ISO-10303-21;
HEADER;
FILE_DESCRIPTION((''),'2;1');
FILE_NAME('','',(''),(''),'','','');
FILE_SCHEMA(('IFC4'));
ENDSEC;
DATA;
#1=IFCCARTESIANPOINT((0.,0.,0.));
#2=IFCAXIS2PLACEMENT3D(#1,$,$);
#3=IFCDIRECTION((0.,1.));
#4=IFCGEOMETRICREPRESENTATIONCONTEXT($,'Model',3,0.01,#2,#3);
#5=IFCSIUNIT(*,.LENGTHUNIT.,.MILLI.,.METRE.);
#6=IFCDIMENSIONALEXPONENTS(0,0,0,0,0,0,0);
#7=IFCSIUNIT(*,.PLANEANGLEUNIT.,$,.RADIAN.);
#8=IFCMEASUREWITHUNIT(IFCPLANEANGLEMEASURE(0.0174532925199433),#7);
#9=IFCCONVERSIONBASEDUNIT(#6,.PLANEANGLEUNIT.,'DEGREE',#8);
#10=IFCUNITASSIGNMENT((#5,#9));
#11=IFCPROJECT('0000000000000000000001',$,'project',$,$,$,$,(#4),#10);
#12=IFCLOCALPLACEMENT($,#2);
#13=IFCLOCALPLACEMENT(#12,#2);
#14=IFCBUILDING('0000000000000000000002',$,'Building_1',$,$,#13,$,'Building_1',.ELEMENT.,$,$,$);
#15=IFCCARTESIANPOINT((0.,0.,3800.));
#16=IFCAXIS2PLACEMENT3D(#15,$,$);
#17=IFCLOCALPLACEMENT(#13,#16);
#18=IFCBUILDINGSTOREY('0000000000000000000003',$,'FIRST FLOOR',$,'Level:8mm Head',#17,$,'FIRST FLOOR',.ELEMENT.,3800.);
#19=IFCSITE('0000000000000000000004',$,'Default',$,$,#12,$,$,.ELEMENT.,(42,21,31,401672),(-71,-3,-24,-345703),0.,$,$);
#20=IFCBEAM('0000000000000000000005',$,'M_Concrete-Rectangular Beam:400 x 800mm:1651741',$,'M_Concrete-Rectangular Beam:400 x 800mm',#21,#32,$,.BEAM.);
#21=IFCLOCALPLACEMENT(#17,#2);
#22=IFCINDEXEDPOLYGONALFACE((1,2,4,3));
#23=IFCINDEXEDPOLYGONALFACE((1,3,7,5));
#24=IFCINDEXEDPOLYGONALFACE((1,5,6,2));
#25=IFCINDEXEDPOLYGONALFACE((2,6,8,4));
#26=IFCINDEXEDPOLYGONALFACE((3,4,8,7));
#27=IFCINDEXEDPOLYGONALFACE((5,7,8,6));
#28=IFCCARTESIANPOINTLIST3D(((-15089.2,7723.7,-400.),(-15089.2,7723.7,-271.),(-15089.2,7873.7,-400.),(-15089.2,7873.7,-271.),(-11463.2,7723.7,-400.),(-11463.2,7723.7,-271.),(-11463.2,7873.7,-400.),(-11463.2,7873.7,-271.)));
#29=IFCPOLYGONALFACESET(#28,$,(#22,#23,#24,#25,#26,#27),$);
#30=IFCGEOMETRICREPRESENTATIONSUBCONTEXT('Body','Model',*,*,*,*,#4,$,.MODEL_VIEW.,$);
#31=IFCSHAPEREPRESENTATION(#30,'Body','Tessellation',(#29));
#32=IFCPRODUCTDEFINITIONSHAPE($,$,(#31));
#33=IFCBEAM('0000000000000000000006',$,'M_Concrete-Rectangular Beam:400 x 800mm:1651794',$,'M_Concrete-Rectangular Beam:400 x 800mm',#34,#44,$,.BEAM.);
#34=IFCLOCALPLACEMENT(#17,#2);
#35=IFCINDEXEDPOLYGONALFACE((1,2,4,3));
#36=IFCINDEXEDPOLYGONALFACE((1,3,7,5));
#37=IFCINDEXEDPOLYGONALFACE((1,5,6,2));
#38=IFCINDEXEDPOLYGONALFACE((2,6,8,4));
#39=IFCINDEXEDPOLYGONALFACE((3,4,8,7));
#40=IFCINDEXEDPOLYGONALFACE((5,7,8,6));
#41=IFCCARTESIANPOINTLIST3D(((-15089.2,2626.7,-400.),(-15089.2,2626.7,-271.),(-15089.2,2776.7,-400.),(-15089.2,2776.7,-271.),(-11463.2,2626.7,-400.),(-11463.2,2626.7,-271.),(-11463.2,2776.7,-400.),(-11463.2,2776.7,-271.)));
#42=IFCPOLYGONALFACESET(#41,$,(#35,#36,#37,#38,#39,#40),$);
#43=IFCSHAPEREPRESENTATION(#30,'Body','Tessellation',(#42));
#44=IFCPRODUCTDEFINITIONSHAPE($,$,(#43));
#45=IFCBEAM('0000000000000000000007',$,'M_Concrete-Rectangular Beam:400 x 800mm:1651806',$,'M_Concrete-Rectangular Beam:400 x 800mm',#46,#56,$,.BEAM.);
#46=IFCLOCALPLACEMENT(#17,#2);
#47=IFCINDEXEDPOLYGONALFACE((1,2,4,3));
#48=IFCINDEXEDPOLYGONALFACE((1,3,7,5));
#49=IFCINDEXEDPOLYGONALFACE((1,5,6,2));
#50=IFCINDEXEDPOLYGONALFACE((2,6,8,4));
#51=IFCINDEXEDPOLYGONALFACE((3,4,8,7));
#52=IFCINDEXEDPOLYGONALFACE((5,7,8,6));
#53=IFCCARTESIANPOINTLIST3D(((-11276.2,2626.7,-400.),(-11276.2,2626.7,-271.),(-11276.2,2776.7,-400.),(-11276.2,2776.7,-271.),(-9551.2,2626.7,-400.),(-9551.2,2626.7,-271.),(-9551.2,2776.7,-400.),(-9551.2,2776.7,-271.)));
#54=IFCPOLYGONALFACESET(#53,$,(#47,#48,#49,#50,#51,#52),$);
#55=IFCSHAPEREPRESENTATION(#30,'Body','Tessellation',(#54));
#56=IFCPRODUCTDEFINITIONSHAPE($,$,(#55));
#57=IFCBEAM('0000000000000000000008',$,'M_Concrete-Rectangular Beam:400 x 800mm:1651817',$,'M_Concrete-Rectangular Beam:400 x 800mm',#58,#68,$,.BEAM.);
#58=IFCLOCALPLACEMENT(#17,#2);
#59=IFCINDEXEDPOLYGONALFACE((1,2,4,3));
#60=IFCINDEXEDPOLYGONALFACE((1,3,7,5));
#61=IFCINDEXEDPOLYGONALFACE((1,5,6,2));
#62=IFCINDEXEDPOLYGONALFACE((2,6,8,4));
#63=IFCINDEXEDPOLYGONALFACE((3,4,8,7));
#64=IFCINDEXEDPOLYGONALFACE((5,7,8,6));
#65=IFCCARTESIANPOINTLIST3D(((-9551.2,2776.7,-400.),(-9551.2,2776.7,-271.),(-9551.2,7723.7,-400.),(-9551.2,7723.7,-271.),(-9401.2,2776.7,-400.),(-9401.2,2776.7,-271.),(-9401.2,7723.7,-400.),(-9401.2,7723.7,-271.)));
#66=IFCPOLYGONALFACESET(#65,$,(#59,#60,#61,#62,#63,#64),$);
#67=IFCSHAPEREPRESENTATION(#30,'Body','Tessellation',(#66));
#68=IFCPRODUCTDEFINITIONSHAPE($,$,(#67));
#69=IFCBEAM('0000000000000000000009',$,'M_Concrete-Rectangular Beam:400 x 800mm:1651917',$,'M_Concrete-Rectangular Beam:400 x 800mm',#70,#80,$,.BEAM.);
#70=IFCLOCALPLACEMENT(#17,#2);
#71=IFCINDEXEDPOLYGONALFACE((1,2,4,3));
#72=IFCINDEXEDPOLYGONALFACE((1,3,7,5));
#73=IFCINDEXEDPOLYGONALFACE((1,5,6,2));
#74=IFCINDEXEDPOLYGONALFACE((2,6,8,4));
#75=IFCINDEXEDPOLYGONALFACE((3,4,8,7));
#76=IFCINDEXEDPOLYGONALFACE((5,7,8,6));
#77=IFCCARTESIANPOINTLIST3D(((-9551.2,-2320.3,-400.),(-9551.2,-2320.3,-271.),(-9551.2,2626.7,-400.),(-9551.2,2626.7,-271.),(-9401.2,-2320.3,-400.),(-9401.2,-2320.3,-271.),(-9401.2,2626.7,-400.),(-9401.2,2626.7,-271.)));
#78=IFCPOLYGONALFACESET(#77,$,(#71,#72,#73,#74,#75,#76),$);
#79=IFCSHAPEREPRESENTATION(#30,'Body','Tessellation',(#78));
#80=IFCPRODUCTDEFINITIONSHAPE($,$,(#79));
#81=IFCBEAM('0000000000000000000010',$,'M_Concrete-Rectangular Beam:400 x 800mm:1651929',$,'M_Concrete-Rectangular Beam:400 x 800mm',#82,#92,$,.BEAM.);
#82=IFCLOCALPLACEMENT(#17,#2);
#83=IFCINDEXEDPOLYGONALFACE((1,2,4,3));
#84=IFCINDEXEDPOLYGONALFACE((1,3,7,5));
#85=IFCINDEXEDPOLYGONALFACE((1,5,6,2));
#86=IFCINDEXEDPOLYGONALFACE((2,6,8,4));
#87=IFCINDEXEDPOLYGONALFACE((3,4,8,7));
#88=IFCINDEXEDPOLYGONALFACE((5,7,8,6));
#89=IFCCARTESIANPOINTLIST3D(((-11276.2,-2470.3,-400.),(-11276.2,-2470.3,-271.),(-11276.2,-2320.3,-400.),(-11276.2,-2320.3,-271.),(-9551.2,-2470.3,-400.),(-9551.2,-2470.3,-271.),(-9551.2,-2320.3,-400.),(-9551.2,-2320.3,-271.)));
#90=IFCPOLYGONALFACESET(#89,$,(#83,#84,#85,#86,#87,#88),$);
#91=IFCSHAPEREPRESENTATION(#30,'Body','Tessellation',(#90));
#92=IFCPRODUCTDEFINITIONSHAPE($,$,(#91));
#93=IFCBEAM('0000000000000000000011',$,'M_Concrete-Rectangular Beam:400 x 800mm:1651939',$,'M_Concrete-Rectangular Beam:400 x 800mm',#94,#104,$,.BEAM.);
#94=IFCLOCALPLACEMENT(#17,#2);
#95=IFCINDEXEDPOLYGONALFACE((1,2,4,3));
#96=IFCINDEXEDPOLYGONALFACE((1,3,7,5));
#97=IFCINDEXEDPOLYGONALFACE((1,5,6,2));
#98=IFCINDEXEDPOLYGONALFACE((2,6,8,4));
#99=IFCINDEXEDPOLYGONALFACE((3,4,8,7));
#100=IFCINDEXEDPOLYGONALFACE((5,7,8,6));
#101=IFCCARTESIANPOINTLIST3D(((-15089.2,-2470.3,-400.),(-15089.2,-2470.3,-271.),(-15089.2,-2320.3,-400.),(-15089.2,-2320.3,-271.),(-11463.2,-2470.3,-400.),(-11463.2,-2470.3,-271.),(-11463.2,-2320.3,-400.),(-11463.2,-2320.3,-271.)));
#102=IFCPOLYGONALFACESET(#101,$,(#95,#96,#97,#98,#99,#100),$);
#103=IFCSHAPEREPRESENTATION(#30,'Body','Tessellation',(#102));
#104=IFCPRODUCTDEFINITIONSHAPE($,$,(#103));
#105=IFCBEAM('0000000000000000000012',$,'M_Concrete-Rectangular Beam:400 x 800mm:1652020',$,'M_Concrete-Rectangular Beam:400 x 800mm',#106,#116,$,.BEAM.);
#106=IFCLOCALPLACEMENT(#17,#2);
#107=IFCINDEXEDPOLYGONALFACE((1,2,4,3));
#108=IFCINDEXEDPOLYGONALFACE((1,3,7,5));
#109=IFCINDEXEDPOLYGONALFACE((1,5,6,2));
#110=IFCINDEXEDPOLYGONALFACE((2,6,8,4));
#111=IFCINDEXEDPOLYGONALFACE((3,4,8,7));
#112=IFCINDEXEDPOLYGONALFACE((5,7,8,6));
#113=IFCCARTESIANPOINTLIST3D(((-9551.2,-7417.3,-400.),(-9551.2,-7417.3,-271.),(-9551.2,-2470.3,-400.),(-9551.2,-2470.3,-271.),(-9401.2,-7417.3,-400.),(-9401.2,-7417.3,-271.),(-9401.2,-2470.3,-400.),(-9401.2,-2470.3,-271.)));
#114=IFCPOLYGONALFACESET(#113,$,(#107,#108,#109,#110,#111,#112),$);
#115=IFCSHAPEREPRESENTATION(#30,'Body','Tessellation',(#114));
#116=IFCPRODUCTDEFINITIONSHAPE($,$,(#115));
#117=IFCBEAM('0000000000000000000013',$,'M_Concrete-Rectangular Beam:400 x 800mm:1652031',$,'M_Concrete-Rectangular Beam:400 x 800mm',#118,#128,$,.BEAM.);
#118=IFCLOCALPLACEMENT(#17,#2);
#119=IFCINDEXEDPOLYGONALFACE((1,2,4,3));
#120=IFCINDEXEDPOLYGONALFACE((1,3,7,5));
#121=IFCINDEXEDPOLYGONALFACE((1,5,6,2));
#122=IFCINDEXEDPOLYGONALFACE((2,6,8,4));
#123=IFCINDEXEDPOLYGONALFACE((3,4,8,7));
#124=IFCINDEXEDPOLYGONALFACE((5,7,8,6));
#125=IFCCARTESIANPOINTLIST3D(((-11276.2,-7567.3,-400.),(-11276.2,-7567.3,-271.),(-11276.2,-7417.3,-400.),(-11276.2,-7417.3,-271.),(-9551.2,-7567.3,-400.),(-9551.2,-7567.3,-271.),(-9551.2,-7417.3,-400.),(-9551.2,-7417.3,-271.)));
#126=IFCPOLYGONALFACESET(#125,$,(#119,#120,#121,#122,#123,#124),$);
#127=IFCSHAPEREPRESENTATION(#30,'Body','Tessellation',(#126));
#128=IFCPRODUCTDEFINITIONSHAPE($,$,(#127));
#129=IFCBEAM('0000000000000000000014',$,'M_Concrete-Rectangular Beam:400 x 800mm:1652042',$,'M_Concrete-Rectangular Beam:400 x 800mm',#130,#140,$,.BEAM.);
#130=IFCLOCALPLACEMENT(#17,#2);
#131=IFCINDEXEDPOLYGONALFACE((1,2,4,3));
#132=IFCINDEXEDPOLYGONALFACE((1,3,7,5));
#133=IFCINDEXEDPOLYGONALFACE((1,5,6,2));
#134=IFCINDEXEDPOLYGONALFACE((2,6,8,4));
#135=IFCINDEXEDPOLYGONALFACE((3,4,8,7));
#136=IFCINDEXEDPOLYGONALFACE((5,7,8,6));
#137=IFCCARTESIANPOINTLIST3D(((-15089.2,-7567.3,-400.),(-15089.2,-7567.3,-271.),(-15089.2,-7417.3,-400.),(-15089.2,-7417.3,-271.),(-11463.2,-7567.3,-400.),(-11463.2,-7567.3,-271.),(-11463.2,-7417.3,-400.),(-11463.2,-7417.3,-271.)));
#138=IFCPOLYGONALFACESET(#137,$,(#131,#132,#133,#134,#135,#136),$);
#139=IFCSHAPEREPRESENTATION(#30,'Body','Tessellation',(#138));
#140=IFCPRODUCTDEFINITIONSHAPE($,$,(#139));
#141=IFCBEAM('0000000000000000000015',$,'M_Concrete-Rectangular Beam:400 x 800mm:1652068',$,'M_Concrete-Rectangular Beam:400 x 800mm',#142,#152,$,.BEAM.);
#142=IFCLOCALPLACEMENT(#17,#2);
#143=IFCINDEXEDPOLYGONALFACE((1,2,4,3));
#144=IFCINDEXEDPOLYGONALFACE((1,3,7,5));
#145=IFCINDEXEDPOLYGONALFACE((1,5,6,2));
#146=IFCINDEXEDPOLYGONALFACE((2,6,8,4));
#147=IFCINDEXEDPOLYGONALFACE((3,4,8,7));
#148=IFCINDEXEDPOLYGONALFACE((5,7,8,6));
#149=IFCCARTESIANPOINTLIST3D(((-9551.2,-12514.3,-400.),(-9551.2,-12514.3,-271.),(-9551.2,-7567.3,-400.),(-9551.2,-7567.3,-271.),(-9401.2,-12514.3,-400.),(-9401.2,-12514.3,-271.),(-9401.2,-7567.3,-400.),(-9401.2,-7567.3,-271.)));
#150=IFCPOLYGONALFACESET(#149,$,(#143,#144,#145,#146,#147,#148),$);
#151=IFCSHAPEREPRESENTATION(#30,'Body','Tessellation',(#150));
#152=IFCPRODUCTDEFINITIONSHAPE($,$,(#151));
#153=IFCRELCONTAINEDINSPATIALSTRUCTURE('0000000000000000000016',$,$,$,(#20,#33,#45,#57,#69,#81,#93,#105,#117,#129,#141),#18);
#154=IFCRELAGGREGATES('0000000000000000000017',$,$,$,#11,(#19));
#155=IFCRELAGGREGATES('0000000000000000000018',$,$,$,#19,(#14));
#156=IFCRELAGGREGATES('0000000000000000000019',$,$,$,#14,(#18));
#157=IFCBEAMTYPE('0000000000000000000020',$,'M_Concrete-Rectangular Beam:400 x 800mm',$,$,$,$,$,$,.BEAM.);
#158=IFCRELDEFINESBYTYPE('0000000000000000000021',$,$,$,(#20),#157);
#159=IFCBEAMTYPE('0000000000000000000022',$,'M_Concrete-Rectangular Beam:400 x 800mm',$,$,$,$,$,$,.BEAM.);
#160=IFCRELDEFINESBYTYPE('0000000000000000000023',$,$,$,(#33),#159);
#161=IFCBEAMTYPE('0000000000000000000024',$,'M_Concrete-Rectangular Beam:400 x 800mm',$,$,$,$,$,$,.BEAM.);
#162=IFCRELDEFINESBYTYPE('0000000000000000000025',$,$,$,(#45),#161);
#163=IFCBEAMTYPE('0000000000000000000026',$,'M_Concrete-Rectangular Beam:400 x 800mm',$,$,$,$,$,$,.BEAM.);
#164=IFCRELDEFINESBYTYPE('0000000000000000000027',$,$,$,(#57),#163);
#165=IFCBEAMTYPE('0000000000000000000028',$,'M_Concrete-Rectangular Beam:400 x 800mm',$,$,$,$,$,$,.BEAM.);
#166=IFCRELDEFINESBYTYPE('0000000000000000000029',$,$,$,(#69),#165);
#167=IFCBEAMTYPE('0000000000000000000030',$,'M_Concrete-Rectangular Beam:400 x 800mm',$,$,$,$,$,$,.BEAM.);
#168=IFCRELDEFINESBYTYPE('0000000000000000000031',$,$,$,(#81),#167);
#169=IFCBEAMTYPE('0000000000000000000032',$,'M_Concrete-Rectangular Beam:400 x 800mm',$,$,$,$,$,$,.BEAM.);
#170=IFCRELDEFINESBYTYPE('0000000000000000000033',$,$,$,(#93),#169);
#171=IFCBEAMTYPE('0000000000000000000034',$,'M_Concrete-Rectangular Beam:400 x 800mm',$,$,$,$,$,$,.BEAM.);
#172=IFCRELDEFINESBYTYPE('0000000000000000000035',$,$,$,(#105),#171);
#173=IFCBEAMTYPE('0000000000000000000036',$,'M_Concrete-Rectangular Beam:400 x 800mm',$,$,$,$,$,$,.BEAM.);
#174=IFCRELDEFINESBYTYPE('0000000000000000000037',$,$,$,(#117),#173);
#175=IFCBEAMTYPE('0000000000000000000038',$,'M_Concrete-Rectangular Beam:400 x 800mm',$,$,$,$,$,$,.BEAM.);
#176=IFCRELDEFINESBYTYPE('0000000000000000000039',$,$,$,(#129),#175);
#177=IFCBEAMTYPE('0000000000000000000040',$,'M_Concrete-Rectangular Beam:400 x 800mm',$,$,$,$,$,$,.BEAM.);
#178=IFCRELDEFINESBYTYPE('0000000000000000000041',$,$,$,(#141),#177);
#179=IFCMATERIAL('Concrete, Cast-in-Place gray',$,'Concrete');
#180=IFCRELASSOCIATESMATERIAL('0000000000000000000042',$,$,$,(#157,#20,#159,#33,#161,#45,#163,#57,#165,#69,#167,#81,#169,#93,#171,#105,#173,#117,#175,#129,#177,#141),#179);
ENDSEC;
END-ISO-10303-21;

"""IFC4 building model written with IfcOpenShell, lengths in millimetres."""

from ifc_helpers import new_model, entity, si_unit, converted_unit, direction, frame, origin, place, context, subcontext, project, spatial, indexed_curve, outline, extrude, source, transform, mapped, material, type_object, type_shapes, element, save


model = new_model("IFC4")

# Units and contexts
model_context = context("Model", 3, precision=0.01, world=origin(), true_north=direction((0.0, 1.0)))
body_context = subcontext(model_context, "Body", "Model", "MODEL_VIEW")
ifc_project = project(units=[si_unit("LENGTHUNIT", "METRE", prefix="MILLI"), converted_unit("PLANEANGLEUNIT", "DEGREE", entity("IfcPlaneAngleMeasure", 0.0174532925199433), si_unit("PLANEANGLEUNIT", "RADIAN"), dimensions=[0, 0, 0, 0, 0, 0, 0])], contexts=[model_context])

# Site, building, storey
site_placement = place(None, origin())
site = spatial("IfcSite", under=ifc_project, at=site_placement, Name="Default", CompositionType="ELEMENT", RefLatitude=(42, 21, 31, 401672), RefLongitude=(-71, -3, -24, -345703), RefElevation=0.0)
building_placement = place(site_placement, origin())
building = spatial("IfcBuilding", under=site, at=building_placement, Name="Building_1", LongName="Building_1", CompositionType="ELEMENT")
storey_placement = place(building_placement, frame((0.0, 0.0, 3800.0)))
storey = spatial("IfcBuildingStorey", under=building, at=storey_placement, Name="FIRST FLOOR", ObjectType="Level:8mm Head", LongName="FIRST FLOOR", CompositionType="ELEMENT", Elevation=3800.0)

# Beams
ifc_material = material(Name="Concrete, Cast-in-Place gray", Category="Concrete")
beam_type_1 = type_object("IfcBeamType", Name="M_Concrete-Rectangular Beam:400 x 800mm", PredefinedType="BEAM", material=ifc_material)
shared_shape_1 = source(origin(), body_context, "Body", "SweptSolid", [
    extrude(outline(indexed_curve([(-64.5, -75.0), (64.5, -75.0), (64.5, 75.0), (-64.5, 75.0), (-64.5, -75.0)], self_intersect=False)), frame((-11463.2, 7798.7, 3464.5), z_axis=(-1.0, 0.0, 0.0), x_axis=(0.0, 0.0, -1.0)), (0.0, 0.0, 1.0), 3626.0),
])
type_shapes(beam_type_1, [shared_shape_1])
beam_1_placement = place(storey_placement, frame((0.0, 0.0, -3800.0)))
element("IfcBeam", 1, at=beam_1_placement, inside=storey, type_object=beam_type_1, material=ifc_material, Name="M_Concrete-Rectangular Beam:400 x 800mm:1651741", ObjectType="M_Concrete-Rectangular Beam:400 x 800mm", PredefinedType="BEAM", context=body_context, shape_type="MappedRepresentation", body=[
    mapped(shared_shape_1, transform((0.0, 0.0, 0.0), scale=1.0)),
])
beam_type_2 = type_object("IfcBeamType", Name="M_Concrete-Rectangular Beam:400 x 800mm", PredefinedType="BEAM", material=ifc_material)
shared_shape_2 = source(origin(), body_context, "Body", "SweptSolid", [
    extrude(outline(indexed_curve([(-64.5, -75.0), (64.5, -75.0), (64.5, 75.0), (-64.5, 75.0), (-64.5, -75.0)], self_intersect=False)), frame((-15089.2, 2701.7, 3464.5), z_axis=(1.0, 0.0, 0.0), x_axis=(0.0, 0.0, -1.0)), (0.0, 0.0, 1.0), 3626.0),
])
type_shapes(beam_type_2, [shared_shape_2])
beam_2_placement = place(storey_placement, frame((0.0, 0.0, -3800.0)))
element("IfcBeam", 2, at=beam_2_placement, inside=storey, type_object=beam_type_2, material=ifc_material, Name="M_Concrete-Rectangular Beam:400 x 800mm:1651794", ObjectType="M_Concrete-Rectangular Beam:400 x 800mm", PredefinedType="BEAM", context=body_context, shape_type="MappedRepresentation", body=[
    mapped(shared_shape_2, transform((0.0, 0.0, 0.0), scale=1.0)),
])
beam_type_3 = type_object("IfcBeamType", Name="M_Concrete-Rectangular Beam:400 x 800mm", PredefinedType="BEAM", material=ifc_material)
shared_shape_3 = source(origin(), body_context, "Body", "SweptSolid", [
    extrude(outline(indexed_curve([(-64.5, -75.0), (64.5, -75.0), (64.5, 75.0), (-64.5, 75.0), (-64.5, -75.0)], self_intersect=False)), frame((-11276.2, 2701.7, 3464.5), z_axis=(1.0, 0.0, 0.0), x_axis=(0.0, 0.0, -1.0)), (0.0, 0.0, 1.0), 1725.0),
])
type_shapes(beam_type_3, [shared_shape_3])
beam_3_placement = place(storey_placement, frame((0.0, 0.0, -3800.0)))
element("IfcBeam", 3, at=beam_3_placement, inside=storey, type_object=beam_type_3, material=ifc_material, Name="M_Concrete-Rectangular Beam:400 x 800mm:1651806", ObjectType="M_Concrete-Rectangular Beam:400 x 800mm", PredefinedType="BEAM", context=body_context, shape_type="MappedRepresentation", body=[
    mapped(shared_shape_3, transform((0.0, 0.0, 0.0), scale=1.0)),
])
beam_type_4 = type_object("IfcBeamType", Name="M_Concrete-Rectangular Beam:400 x 800mm", PredefinedType="BEAM", material=ifc_material)
shared_shape_4 = source(origin(), body_context, "Body", "SweptSolid", [
    extrude(outline(indexed_curve([(-75.0, -64.5), (75.0, -64.5), (75.0, 64.5), (-75.0, 64.5), (-75.0, -64.5)], self_intersect=False)), frame((-9476.2, 2776.7, 3464.5), z_axis=(0.0, 1.0, 0.0), x_axis=(-1.0, 0.0, 0.0)), (0.0, 0.0, 1.0), 4947.0),
])
type_shapes(beam_type_4, [shared_shape_4])
beam_4_placement = place(storey_placement, frame((0.0, 0.0, -3800.0)))
element("IfcBeam", 4, at=beam_4_placement, inside=storey, type_object=beam_type_4, material=ifc_material, Name="M_Concrete-Rectangular Beam:400 x 800mm:1651817", ObjectType="M_Concrete-Rectangular Beam:400 x 800mm", PredefinedType="BEAM", context=body_context, shape_type="MappedRepresentation", body=[
    mapped(shared_shape_4, transform((0.0, 0.0, 0.0), scale=1.0)),
])
beam_type_5 = type_object("IfcBeamType", Name="M_Concrete-Rectangular Beam:400 x 800mm", PredefinedType="BEAM", material=ifc_material)
shared_shape_5 = source(origin(), body_context, "Body", "SweptSolid", [
    extrude(outline(indexed_curve([(-75.0, -64.5), (75.0, -64.5), (75.0, 64.5), (-75.0, 64.5), (-75.0, -64.5)], self_intersect=False)), frame((-9476.2, 2626.7, 3464.5), z_axis=(0.0, -1.0, 0.0), x_axis=(-1.0, 0.0, 0.0)), (0.0, 0.0, 1.0), 4947.0),
])
type_shapes(beam_type_5, [shared_shape_5])
beam_5_placement = place(storey_placement, frame((0.0, 0.0, -3800.0)))
element("IfcBeam", 5, at=beam_5_placement, inside=storey, type_object=beam_type_5, material=ifc_material, Name="M_Concrete-Rectangular Beam:400 x 800mm:1651917", ObjectType="M_Concrete-Rectangular Beam:400 x 800mm", PredefinedType="BEAM", context=body_context, shape_type="MappedRepresentation", body=[
    mapped(shared_shape_5, transform((0.0, 0.0, 0.0), scale=1.0)),
])
beam_type_6 = type_object("IfcBeamType", Name="M_Concrete-Rectangular Beam:400 x 800mm", PredefinedType="BEAM", material=ifc_material)
shared_shape_6 = source(origin(), body_context, "Body", "SweptSolid", [
    extrude(outline(indexed_curve([(-64.5, -75.0), (64.5, -75.0), (64.5, 75.0), (-64.5, 75.0), (-64.5, -75.0)], self_intersect=False)), frame((-9551.2, -2395.3, 3464.5), z_axis=(-1.0, 0.0, 0.0), x_axis=(0.0, 0.0, -1.0)), (0.0, 0.0, 1.0), 1725.0),
])
type_shapes(beam_type_6, [shared_shape_6])
beam_6_placement = place(storey_placement, frame((0.0, 0.0, -3800.0)))
element("IfcBeam", 6, at=beam_6_placement, inside=storey, type_object=beam_type_6, material=ifc_material, Name="M_Concrete-Rectangular Beam:400 x 800mm:1651929", ObjectType="M_Concrete-Rectangular Beam:400 x 800mm", PredefinedType="BEAM", context=body_context, shape_type="MappedRepresentation", body=[
    mapped(shared_shape_6, transform((0.0, 0.0, 0.0), scale=1.0)),
])
beam_type_7 = type_object("IfcBeamType", Name="M_Concrete-Rectangular Beam:400 x 800mm", PredefinedType="BEAM", material=ifc_material)
shared_shape_7 = source(origin(), body_context, "Body", "SweptSolid", [
    extrude(outline(indexed_curve([(-64.5, -75.0), (64.5, -75.0), (64.5, 75.0), (-64.5, 75.0), (-64.5, -75.0)], self_intersect=False)), frame((-11463.2, -2395.3, 3464.5), z_axis=(-1.0, 0.0, 0.0), x_axis=(0.0, 0.0, -1.0)), (0.0, 0.0, 1.0), 3626.0),
])
type_shapes(beam_type_7, [shared_shape_7])
beam_7_placement = place(storey_placement, frame((0.0, 0.0, -3800.0)))
element("IfcBeam", 7, at=beam_7_placement, inside=storey, type_object=beam_type_7, material=ifc_material, Name="M_Concrete-Rectangular Beam:400 x 800mm:1651939", ObjectType="M_Concrete-Rectangular Beam:400 x 800mm", PredefinedType="BEAM", context=body_context, shape_type="MappedRepresentation", body=[
    mapped(shared_shape_7, transform((0.0, 0.0, 0.0), scale=1.0)),
])
beam_type_8 = type_object("IfcBeamType", Name="M_Concrete-Rectangular Beam:400 x 800mm", PredefinedType="BEAM", material=ifc_material)
shared_shape_8 = source(origin(), body_context, "Body", "SweptSolid", [
    extrude(outline(indexed_curve([(-75.0, -64.5), (75.0, -64.5), (75.0, 64.5), (-75.0, 64.5), (-75.0, -64.5)], self_intersect=False)), frame((-9476.2, -2470.3, 3464.5), z_axis=(0.0, -1.0, 0.0), x_axis=(-1.0, 0.0, 0.0)), (0.0, 0.0, 1.0), 4947.0),
])
type_shapes(beam_type_8, [shared_shape_8])
beam_8_placement = place(storey_placement, frame((0.0, 0.0, -3800.0)))
element("IfcBeam", 8, at=beam_8_placement, inside=storey, type_object=beam_type_8, material=ifc_material, Name="M_Concrete-Rectangular Beam:400 x 800mm:1652020", ObjectType="M_Concrete-Rectangular Beam:400 x 800mm", PredefinedType="BEAM", context=body_context, shape_type="MappedRepresentation", body=[
    mapped(shared_shape_8, transform((0.0, 0.0, 0.0), scale=1.0)),
])
beam_type_9 = type_object("IfcBeamType", Name="M_Concrete-Rectangular Beam:400 x 800mm", PredefinedType="BEAM", material=ifc_material)
shared_shape_9 = source(origin(), body_context, "Body", "SweptSolid", [
    extrude(outline(indexed_curve([(-64.5, -75.0), (64.5, -75.0), (64.5, 75.0), (-64.5, 75.0), (-64.5, -75.0)], self_intersect=False)), frame((-9551.2, -7492.3, 3464.5), z_axis=(-1.0, 0.0, 0.0), x_axis=(0.0, 0.0, -1.0)), (0.0, 0.0, 1.0), 1725.0),
])
type_shapes(beam_type_9, [shared_shape_9])
beam_9_placement = place(storey_placement, frame((0.0, 0.0, -3800.0)))
element("IfcBeam", 9, at=beam_9_placement, inside=storey, type_object=beam_type_9, material=ifc_material, Name="M_Concrete-Rectangular Beam:400 x 800mm:1652031", ObjectType="M_Concrete-Rectangular Beam:400 x 800mm", PredefinedType="BEAM", context=body_context, shape_type="MappedRepresentation", body=[
    mapped(shared_shape_9, transform((0.0, 0.0, 0.0), scale=1.0)),
])
beam_type_10 = type_object("IfcBeamType", Name="M_Concrete-Rectangular Beam:400 x 800mm", PredefinedType="BEAM", material=ifc_material)
shared_shape_10 = source(origin(), body_context, "Body", "SweptSolid", [
    extrude(outline(indexed_curve([(-64.5, -75.0), (64.5, -75.0), (64.5, 75.0), (-64.5, 75.0), (-64.5, -75.0)], self_intersect=False)), frame((-11463.2, -7492.3, 3464.5), z_axis=(-1.0, 0.0, 0.0), x_axis=(0.0, 0.0, -1.0)), (0.0, 0.0, 1.0), 3626.0),
])
type_shapes(beam_type_10, [shared_shape_10])
beam_10_placement = place(storey_placement, frame((0.0, 0.0, -3800.0)))
element("IfcBeam", 10, at=beam_10_placement, inside=storey, type_object=beam_type_10, material=ifc_material, Name="M_Concrete-Rectangular Beam:400 x 800mm:1652042", ObjectType="M_Concrete-Rectangular Beam:400 x 800mm", PredefinedType="BEAM", context=body_context, shape_type="MappedRepresentation", body=[
    mapped(shared_shape_10, transform((0.0, 0.0, 0.0), scale=1.0)),
])
beam_type_11 = type_object("IfcBeamType", Name="M_Concrete-Rectangular Beam:400 x 800mm", PredefinedType="BEAM", material=ifc_material)
shared_shape_11 = source(origin(), body_context, "Body", "SweptSolid", [
    extrude(outline(indexed_curve([(-75.0, -64.5), (75.0, -64.5), (75.0, 64.5), (-75.0, 64.5), (-75.0, -64.5)], self_intersect=False)), frame((-9476.2, -7567.3, 3464.5), z_axis=(0.0, -1.0, 0.0), x_axis=(-1.0, 0.0, 0.0)), (0.0, 0.0, 1.0), 4947.0),
])
type_shapes(beam_type_11, [shared_shape_11])
beam_11_placement = place(storey_placement, frame((0.0, 0.0, -3800.0)))
element("IfcBeam", 11, at=beam_11_placement, inside=storey, type_object=beam_type_11, material=ifc_material, Name="M_Concrete-Rectangular Beam:400 x 800mm:1652068", ObjectType="M_Concrete-Rectangular Beam:400 x 800mm", PredefinedType="BEAM", context=body_context, shape_type="MappedRepresentation", body=[
    mapped(shared_shape_11, transform((0.0, 0.0, 0.0), scale=1.0)),
])

save(model, "model.ifc")
